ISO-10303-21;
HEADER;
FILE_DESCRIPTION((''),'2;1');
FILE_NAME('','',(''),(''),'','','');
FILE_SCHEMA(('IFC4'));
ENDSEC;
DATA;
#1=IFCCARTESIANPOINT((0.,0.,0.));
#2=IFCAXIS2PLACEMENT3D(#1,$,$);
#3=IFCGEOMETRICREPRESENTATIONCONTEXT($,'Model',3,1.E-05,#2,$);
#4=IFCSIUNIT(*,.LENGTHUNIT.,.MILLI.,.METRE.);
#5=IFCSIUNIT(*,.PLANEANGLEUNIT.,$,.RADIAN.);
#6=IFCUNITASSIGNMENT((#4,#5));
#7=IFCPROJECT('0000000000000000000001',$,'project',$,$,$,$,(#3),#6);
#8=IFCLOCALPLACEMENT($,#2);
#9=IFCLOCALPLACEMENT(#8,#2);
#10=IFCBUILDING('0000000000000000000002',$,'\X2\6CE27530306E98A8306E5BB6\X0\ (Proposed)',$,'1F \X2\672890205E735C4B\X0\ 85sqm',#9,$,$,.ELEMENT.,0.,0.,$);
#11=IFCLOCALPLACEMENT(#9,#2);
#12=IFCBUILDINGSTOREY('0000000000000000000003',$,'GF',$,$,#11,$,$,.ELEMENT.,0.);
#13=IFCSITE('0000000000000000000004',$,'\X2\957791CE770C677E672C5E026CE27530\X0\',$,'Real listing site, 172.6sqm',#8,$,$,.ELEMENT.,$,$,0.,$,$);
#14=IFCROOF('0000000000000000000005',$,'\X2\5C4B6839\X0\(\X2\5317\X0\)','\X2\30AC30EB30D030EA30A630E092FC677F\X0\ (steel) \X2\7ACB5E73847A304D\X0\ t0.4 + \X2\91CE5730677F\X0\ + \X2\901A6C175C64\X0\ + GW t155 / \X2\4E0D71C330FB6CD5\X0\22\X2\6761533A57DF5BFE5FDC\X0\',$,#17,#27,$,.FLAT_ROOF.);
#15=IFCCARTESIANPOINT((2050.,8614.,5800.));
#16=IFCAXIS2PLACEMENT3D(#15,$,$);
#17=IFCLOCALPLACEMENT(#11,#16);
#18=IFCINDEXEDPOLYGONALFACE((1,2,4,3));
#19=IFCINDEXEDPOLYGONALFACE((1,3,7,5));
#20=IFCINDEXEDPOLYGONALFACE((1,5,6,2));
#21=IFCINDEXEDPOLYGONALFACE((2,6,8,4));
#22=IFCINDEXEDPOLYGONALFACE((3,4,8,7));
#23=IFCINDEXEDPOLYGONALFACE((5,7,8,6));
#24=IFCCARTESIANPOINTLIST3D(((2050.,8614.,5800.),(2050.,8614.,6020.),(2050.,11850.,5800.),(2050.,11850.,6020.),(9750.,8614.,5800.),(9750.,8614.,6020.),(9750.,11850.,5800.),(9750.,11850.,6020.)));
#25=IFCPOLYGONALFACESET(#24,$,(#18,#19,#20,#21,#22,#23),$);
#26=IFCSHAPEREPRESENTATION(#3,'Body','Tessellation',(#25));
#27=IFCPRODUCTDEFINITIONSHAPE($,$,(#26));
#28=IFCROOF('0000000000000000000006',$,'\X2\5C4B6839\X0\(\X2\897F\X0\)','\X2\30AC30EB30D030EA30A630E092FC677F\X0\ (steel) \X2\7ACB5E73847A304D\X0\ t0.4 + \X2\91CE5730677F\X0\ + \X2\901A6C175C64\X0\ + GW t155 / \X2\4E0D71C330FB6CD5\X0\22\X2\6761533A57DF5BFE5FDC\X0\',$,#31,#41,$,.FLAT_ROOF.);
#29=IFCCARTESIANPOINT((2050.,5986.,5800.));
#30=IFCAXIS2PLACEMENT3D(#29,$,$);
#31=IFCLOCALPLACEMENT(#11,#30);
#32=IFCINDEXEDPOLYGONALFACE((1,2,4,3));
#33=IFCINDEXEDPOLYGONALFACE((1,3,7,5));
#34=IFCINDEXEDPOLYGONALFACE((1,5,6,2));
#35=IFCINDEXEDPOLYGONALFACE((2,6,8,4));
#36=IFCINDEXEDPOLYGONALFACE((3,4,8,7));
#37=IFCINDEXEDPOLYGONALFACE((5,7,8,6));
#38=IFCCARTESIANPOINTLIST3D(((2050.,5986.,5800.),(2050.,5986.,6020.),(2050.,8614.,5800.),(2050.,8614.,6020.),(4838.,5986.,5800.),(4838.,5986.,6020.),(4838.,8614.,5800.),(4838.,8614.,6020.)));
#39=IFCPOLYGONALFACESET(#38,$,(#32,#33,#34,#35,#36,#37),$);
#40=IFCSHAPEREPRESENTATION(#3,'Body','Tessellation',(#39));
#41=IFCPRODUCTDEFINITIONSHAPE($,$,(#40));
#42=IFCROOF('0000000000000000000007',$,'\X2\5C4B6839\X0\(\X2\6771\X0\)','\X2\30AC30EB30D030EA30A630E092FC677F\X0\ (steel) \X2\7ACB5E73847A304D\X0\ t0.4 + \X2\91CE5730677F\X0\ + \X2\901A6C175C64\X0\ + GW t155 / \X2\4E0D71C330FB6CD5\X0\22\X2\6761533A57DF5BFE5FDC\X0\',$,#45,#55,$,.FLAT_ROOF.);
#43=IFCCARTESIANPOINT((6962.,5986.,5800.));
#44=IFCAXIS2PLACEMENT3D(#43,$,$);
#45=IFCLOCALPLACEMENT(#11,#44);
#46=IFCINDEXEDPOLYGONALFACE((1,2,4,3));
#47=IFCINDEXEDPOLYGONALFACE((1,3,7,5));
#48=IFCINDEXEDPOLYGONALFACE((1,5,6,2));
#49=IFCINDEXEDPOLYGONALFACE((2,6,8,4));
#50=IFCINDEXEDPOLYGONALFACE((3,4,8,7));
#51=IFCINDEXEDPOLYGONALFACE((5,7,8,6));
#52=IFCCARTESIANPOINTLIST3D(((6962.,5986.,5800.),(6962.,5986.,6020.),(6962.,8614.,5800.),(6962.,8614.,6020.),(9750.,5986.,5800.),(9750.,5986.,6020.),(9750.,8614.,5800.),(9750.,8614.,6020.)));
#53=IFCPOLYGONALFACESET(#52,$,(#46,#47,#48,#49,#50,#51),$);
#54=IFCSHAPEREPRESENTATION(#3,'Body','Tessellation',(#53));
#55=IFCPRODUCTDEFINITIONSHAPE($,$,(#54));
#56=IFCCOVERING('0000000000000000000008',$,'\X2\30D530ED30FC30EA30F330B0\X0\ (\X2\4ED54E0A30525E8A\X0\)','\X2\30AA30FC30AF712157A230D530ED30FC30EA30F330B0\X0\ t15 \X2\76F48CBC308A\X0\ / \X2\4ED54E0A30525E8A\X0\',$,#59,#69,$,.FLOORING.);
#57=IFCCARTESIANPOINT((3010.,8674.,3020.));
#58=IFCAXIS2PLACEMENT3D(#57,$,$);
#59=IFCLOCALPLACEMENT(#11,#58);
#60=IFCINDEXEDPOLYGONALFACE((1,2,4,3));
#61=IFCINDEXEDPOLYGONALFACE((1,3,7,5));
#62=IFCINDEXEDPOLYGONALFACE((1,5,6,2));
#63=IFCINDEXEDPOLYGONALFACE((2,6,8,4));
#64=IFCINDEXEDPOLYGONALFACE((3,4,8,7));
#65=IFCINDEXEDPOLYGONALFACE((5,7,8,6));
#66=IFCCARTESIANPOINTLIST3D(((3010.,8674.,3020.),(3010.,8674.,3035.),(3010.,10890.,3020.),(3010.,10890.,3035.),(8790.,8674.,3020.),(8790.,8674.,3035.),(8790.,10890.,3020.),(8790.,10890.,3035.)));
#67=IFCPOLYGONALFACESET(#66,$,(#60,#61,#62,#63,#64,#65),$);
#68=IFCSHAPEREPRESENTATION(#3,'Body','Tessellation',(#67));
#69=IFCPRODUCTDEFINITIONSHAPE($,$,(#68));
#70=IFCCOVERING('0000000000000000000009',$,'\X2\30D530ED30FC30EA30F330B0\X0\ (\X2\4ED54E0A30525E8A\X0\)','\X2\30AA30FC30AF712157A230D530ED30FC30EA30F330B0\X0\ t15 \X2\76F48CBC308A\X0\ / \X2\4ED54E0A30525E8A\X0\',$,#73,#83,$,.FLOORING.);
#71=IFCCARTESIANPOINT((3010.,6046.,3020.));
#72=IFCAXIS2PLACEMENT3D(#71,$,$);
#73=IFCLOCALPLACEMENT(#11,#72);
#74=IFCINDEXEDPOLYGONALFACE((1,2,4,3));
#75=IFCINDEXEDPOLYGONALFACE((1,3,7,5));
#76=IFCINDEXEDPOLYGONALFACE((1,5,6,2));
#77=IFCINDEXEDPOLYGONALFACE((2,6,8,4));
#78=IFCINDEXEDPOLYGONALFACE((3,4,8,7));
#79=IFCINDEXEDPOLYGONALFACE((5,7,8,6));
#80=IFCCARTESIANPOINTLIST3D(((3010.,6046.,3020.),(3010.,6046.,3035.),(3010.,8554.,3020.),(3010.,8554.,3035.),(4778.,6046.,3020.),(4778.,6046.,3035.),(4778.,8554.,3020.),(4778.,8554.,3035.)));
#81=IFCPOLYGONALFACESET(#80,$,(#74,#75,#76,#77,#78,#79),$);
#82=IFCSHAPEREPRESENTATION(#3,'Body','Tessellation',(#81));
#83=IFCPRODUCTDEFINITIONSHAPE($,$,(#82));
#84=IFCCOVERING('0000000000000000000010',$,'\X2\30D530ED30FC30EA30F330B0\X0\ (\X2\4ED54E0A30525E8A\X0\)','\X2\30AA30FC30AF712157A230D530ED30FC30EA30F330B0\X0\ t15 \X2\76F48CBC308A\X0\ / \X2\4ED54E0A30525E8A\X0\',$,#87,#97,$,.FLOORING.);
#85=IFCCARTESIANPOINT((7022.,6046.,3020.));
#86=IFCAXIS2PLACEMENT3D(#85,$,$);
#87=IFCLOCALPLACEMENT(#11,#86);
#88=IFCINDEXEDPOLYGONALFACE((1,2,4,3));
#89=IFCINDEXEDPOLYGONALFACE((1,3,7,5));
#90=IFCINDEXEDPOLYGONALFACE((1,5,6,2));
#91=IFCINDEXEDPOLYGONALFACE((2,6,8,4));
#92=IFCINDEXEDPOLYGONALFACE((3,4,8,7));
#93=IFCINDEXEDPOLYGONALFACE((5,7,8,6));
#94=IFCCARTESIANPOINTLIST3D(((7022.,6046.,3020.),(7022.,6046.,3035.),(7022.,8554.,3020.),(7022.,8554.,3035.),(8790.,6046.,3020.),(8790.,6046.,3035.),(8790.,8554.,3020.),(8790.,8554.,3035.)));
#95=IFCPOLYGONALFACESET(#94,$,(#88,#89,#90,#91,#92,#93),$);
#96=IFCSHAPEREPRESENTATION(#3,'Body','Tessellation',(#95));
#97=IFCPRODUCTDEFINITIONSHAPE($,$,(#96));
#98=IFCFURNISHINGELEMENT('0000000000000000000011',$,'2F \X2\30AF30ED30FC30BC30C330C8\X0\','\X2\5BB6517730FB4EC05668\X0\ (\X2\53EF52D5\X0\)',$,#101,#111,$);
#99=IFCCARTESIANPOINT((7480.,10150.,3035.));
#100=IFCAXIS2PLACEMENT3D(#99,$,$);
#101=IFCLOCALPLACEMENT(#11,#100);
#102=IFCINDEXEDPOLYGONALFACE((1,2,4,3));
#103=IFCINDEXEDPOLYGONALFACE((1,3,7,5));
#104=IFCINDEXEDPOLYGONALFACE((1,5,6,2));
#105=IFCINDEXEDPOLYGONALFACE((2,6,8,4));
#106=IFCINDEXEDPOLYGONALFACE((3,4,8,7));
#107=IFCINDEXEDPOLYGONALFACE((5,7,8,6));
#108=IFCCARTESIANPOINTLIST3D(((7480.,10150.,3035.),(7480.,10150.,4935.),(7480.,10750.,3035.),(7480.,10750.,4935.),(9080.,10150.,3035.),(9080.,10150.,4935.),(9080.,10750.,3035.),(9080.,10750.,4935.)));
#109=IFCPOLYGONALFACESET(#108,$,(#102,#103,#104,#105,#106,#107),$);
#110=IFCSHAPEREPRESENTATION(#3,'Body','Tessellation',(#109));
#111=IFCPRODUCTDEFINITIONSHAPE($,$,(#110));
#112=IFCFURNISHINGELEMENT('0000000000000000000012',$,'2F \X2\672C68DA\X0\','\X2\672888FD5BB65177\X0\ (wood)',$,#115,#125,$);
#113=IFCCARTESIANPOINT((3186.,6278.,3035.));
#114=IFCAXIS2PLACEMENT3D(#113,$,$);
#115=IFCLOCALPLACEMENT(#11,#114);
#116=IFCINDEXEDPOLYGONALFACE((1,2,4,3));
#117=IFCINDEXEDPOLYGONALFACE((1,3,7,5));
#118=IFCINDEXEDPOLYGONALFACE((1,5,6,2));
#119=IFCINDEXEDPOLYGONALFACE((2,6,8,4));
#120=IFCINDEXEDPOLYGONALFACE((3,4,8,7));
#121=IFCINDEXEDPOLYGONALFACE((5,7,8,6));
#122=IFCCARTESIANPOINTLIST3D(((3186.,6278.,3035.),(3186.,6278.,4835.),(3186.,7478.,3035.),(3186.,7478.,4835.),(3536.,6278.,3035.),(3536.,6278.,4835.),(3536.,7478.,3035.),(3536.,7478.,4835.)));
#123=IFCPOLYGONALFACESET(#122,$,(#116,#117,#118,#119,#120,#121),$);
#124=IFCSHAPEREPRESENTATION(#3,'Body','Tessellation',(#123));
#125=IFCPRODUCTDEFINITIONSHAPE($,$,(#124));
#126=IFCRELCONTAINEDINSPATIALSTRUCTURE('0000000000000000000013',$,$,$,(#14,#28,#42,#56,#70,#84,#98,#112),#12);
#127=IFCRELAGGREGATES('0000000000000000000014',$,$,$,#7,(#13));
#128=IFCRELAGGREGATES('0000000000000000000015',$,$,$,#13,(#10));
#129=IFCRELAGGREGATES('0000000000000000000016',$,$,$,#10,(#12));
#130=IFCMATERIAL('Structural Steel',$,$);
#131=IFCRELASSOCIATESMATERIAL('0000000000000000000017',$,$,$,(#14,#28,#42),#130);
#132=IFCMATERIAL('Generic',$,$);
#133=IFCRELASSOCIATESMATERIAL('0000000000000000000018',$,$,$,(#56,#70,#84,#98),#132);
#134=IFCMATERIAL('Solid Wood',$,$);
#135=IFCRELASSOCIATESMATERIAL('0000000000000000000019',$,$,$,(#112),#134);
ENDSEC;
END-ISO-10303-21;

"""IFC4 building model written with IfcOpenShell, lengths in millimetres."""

from ifc_helpers import new_model, si_unit, frame, frame_2d, origin, place, context, project, spatial, rectangle, extrude, material, element, save


model = new_model("IFC4")

# Units and contexts
model_context = context("Model", 3, precision=1e-05, world=origin())
ifc_project = project(units=[si_unit("LENGTHUNIT", "METRE", prefix="MILLI"), si_unit("PLANEANGLEUNIT", "RADIAN")], contexts=[model_context])

# Site, building, storey
site_placement = place(None, origin())
site = spatial("IfcSite", under=ifc_project, at=site_placement, Name="長野県松本市波田", ObjectType="Real listing site, 172.6sqm", CompositionType="ELEMENT", RefElevation=0.0)
building_placement = place(site_placement, origin())
building = spatial("IfcBuilding", under=site, at=building_placement, Name="波田の風の家 (Proposed)", ObjectType="1F 木造平屋 85sqm", CompositionType="ELEMENT", ElevationOfRefHeight=0.0, ElevationOfTerrain=0.0)
storey_placement = place(building_placement, origin())
storey = spatial("IfcBuildingStorey", under=building, at=storey_placement, Name="GF", CompositionType="ELEMENT", Elevation=0.0)

# Shared definitions
ifc_material_1 = material(Name="Solid Wood")

# Shared definitions
ifc_material_2 = material(Name="Generic")

# Roofs
ifc_material_3 = material(Name="Structural Steel")
for number, where, name in (
    (1, (2050.0, 8614.0, 5800.0), "屋根(北)"),
):
    element("IfcRoof", number, at=place(storey_placement, frame(where)), inside=storey, material=ifc_material_3, Name=name, Description="ガルバリウム鋼板 (steel) 立平葺き t0.4 + 野地板 + 通気層 + GW t155 / 不燃・法22条区域対応", PredefinedType="FLAT_ROOF", context=model_context, shape_type="SweptSolid", body=[
        extrude(rectangle(XDim=7700.0, YDim=3236.0, at=frame_2d((3850.0, 1618.0))), frame((2050.0, 8614.0, 5800.0)), (0.0, 0.0, 1.0), 220.0),
    ])
roof_1_placement = place(storey_placement, frame((2050.0, 5986.0, 5800.0)))
element("IfcRoof", 2, at=roof_1_placement, inside=storey, material=ifc_material_3, Name="屋根(西)", Description="ガルバリウム鋼板 (steel) 立平葺き t0.4 + 野地板 + 通気層 + GW t155 / 不燃・法22条区域対応", PredefinedType="FLAT_ROOF", context=model_context, shape_type="SweptSolid", body=[
    extrude(rectangle(XDim=2788.0, YDim=2628.0, at=frame_2d((1394.0, 1314.0))), frame((2050.0, 5986.0, 5800.0)), (0.0, 0.0, 1.0), 220.0),
])
roof_2_placement = place(storey_placement, frame((6962.0, 5986.0, 5800.0)))
element("IfcRoof", 3, at=roof_2_placement, inside=storey, material=ifc_material_3, Name="屋根(東)", Description="ガルバリウム鋼板 (steel) 立平葺き t0.4 + 野地板 + 通気層 + GW t155 / 不燃・法22条区域対応", PredefinedType="FLAT_ROOF", context=model_context, shape_type="SweptSolid", body=[
    extrude(rectangle(XDim=2788.0, YDim=2628.0, at=frame_2d((1394.0, 1314.0))), frame((6962.0, 5986.0, 5800.0)), (0.0, 0.0, 1.0), 220.0),
])

# Coverings
covering_1_placement = place(storey_placement, frame((3010.0, 8674.0, 3020.0)))
element("IfcCovering", 4, at=covering_1_placement, inside=storey, material=ifc_material_2, Name="フローリング (仕上げ床)", Description="オーク無垢フローリング t15 直貼り / 仕上げ床", PredefinedType="FLOORING", context=model_context, shape_type="SweptSolid", body=[
    extrude(rectangle(XDim=5780.0, YDim=2216.0, at=frame_2d((2890.0, 1108.0))), frame((3010.0, 8674.0, 3020.0)), (0.0, 0.0, 1.0), 15.0),
])
covering_2_placement = place(storey_placement, frame((3010.0, 6046.0, 3020.0)))
element("IfcCovering", 5, at=covering_2_placement, inside=storey, material=ifc_material_2, Name="フローリング (仕上げ床)", Description="オーク無垢フローリング t15 直貼り / 仕上げ床", PredefinedType="FLOORING", context=model_context, shape_type="SweptSolid", body=[
    extrude(rectangle(XDim=1768.0, YDim=2508.0, at=frame_2d((884.0, 1254.0))), frame((3010.0, 6046.0, 3020.0)), (0.0, 0.0, 1.0), 15.0),
])
covering_3_placement = place(storey_placement, frame((7022.0, 6046.0, 3020.0)))
element("IfcCovering", 6, at=covering_3_placement, inside=storey, material=ifc_material_2, Name="フローリング (仕上げ床)", Description="オーク無垢フローリング t15 直貼り / 仕上げ床", PredefinedType="FLOORING", context=model_context, shape_type="SweptSolid", body=[
    extrude(rectangle(XDim=1768.0, YDim=2508.0, at=frame_2d((884.0, 1254.0))), frame((7022.0, 6046.0, 3020.0)), (0.0, 0.0, 1.0), 15.0),
])

# Furnishing elements
furnishing_1_placement = place(storey_placement, frame((7480.0, 10150.0, 3035.0)))
element("IfcFurnishingElement", 7, at=furnishing_1_placement, inside=storey, material=ifc_material_2, Name="2F クローゼット", Description="家具・什器 (可動)", context=model_context, shape_type="SweptSolid", body=[
    extrude(rectangle(XDim=1600.0, YDim=600.0, at=frame_2d((800.0, 300.0))), frame((7480.0, 10150.0, 3035.0)), (0.0, 0.0, 1.0), 1900.0),
])
furnishing_2_placement = place(storey_placement, frame((3186.0, 6278.0, 3035.0)))
element("IfcFurnishingElement", 8, at=furnishing_2_placement, inside=storey, material=ifc_material_1, Name="2F 本棚", Description="木製家具 (wood)", context=model_context, shape_type="SweptSolid", body=[
    extrude(rectangle(XDim=350.0, YDim=1200.0, at=frame_2d((175.0, 600.0))), frame((3186.0, 6278.0, 3035.0)), (0.0, 0.0, 1.0), 1800.0),
])

save(model, "model.ifc")
